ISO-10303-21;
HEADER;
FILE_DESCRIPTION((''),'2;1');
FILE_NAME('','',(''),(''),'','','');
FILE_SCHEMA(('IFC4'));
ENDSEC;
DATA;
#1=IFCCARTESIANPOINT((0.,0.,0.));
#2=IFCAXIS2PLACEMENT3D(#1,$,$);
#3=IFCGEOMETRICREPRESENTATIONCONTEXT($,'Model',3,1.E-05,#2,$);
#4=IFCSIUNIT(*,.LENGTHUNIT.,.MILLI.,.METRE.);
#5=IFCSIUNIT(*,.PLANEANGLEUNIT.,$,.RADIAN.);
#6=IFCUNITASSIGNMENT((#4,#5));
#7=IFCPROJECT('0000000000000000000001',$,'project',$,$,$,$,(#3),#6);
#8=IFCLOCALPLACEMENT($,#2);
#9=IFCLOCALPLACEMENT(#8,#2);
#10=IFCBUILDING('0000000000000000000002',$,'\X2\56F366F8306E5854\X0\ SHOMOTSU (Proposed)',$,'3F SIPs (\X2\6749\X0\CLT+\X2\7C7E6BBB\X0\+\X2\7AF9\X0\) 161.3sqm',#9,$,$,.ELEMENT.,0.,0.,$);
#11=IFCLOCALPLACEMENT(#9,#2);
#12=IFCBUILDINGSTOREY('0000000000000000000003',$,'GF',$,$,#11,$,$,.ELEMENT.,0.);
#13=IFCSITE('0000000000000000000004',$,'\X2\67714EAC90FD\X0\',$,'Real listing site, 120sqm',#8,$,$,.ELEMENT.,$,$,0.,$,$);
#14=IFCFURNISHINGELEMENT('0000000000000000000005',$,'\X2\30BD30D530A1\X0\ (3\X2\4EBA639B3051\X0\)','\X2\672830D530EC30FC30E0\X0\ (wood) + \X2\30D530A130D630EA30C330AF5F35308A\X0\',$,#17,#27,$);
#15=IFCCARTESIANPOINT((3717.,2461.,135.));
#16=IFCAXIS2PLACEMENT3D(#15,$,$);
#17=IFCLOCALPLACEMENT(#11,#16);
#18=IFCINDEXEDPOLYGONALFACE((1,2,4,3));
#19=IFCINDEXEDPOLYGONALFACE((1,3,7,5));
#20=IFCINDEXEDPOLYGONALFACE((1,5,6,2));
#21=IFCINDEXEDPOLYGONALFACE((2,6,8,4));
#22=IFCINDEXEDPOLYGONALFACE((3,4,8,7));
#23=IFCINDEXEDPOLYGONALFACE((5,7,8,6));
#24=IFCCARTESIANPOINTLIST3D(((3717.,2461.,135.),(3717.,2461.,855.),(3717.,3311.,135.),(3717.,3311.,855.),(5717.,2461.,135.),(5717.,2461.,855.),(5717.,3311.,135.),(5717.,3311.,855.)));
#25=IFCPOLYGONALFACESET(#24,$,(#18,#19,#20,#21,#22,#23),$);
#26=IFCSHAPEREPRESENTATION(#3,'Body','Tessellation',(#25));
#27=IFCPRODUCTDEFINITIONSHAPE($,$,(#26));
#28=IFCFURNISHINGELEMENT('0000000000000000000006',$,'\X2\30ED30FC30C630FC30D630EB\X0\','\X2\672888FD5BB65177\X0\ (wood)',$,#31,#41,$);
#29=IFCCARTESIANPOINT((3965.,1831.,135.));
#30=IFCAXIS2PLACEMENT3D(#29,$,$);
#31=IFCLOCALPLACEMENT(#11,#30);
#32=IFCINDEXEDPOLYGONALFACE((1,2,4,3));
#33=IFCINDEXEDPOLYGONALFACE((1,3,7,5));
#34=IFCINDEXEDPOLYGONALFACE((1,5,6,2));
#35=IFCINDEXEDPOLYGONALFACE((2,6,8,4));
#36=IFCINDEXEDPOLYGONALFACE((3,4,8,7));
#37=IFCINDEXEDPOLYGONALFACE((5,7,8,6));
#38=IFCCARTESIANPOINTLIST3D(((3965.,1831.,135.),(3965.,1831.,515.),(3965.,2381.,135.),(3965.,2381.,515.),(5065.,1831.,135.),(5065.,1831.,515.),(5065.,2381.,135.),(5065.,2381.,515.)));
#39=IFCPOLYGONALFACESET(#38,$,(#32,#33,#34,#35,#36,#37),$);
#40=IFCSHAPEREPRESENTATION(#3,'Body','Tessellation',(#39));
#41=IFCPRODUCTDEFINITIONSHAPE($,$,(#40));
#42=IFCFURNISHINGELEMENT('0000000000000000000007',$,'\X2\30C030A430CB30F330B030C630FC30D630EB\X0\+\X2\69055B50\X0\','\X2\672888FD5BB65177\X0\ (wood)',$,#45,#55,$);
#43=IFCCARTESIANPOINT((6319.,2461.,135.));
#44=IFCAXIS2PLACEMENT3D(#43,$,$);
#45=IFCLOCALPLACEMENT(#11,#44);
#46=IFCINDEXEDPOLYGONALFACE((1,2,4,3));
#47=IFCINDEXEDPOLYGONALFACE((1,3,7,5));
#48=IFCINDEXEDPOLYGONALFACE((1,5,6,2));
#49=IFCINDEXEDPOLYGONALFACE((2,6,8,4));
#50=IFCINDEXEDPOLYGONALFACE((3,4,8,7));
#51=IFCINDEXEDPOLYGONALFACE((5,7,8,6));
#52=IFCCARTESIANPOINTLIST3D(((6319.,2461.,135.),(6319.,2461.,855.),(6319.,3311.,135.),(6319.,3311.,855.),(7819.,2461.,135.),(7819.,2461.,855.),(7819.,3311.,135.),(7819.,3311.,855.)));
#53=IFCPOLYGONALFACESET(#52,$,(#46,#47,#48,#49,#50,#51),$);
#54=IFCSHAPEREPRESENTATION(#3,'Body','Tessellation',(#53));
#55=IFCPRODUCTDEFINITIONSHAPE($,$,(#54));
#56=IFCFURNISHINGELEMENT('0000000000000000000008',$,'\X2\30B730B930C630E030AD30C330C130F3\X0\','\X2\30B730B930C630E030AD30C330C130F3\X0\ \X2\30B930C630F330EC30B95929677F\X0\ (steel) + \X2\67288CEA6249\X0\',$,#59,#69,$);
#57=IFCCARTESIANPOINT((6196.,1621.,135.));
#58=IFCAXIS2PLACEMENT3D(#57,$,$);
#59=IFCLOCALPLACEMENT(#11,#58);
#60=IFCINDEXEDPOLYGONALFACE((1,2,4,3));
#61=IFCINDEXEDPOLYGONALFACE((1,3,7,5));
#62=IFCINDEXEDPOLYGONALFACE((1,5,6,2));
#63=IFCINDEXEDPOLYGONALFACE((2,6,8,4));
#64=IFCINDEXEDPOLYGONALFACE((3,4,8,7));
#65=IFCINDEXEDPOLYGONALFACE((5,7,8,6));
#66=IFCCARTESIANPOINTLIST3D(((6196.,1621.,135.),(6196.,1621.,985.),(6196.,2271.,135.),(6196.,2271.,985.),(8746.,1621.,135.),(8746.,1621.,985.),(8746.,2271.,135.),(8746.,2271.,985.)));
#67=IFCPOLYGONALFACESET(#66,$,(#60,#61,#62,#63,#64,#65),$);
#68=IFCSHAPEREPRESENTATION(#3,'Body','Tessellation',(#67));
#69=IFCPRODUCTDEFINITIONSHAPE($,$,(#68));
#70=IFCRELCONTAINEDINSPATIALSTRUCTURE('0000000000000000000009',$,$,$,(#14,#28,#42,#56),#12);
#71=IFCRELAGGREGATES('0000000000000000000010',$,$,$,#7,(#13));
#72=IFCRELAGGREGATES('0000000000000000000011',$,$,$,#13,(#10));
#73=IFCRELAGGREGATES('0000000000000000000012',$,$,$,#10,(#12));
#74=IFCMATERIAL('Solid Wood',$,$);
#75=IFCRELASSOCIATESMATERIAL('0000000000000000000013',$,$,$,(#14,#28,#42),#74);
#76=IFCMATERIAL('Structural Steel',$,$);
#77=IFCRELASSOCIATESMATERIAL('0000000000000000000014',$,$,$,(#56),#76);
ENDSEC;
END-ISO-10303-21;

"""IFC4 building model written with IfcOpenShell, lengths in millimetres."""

from ifc_helpers import new_model, si_unit, frame, frame_2d, origin, place, context, project, spatial, rectangle, extrude, material, element, save


model = new_model("IFC4")

# Units and contexts
model_context = context("Model", 3, precision=1e-05, world=origin())
ifc_project = project(units=[si_unit("LENGTHUNIT", "METRE", prefix="MILLI"), si_unit("PLANEANGLEUNIT", "RADIAN")], contexts=[model_context])

# Site, building, storey
site_placement = place(None, origin())
site = spatial("IfcSite", under=ifc_project, at=site_placement, Name="東京都", ObjectType="Real listing site, 120sqm", CompositionType="ELEMENT", RefElevation=0.0)
building_placement = place(site_placement, origin())
building = spatial("IfcBuilding", under=site, at=building_placement, Name="図書の塔 SHOMOTSU (Proposed)", ObjectType="3F SIPs (杉CLT+籾殻+竹) 161.3sqm", CompositionType="ELEMENT", ElevationOfRefHeight=0.0, ElevationOfTerrain=0.0)
storey_placement = place(building_placement, origin())
storey = spatial("IfcBuildingStorey", under=building, at=storey_placement, Name="GF", CompositionType="ELEMENT", Elevation=0.0)

# Shared definitions
ifc_material_1 = material(Name="Solid Wood")

# Furnishing elements
furnishing_1_placement = place(storey_placement, frame((3717.0, 2461.0, 135.0)))
element("IfcFurnishingElement", 1, at=furnishing_1_placement, inside=storey, material=ifc_material_1, Name="ソファ (3人掛け)", Description="木フレーム (wood) + ファブリック張り", context=model_context, shape_type="SweptSolid", body=[
    extrude(rectangle(XDim=2000.0, YDim=850.0, at=frame_2d((1000.0, 425.0))), frame((3717.0, 2461.0, 135.0)), (0.0, 0.0, 1.0), 720.0),
])
furnishing_2_placement = place(storey_placement, frame((3965.0, 1831.0, 135.0)))
element("IfcFurnishingElement", 2, at=furnishing_2_placement, inside=storey, material=ifc_material_1, Name="ローテーブル", Description="木製家具 (wood)", context=model_context, shape_type="SweptSolid", body=[
    extrude(rectangle(XDim=1100.0, YDim=550.0, at=frame_2d((550.0, 275.0))), frame((3965.0, 1831.0, 135.0)), (0.0, 0.0, 1.0), 380.0),
])
furnishing_3_placement = place(storey_placement, frame((6319.0, 2461.0, 135.0)))
element("IfcFurnishingElement", 3, at=furnishing_3_placement, inside=storey, material=ifc_material_1, Name="ダイニングテーブル+椅子", Description="木製家具 (wood)", context=model_context, shape_type="SweptSolid", body=[
    extrude(rectangle(XDim=1500.0, YDim=850.0, at=frame_2d((750.0, 425.0))), frame((6319.0, 2461.0, 135.0)), (0.0, 0.0, 1.0), 720.0),
])
ifc_material_2 = material(Name="Structural Steel")
furnishing_4_placement = place(storey_placement, frame((6196.0, 1621.0, 135.0)))
element("IfcFurnishingElement", 4, at=furnishing_4_placement, inside=storey, material=ifc_material_2, Name="システムキッチン", Description="システムキッチン ステンレス天板 (steel) + 木質扉", context=model_context, shape_type="SweptSolid", body=[
    extrude(rectangle(XDim=2550.0, YDim=650.0, at=frame_2d((1275.0, 325.0))), frame((6196.0, 1621.0, 135.0)), (0.0, 0.0, 1.0), 850.0),
])

save(model, "model.ifc")
